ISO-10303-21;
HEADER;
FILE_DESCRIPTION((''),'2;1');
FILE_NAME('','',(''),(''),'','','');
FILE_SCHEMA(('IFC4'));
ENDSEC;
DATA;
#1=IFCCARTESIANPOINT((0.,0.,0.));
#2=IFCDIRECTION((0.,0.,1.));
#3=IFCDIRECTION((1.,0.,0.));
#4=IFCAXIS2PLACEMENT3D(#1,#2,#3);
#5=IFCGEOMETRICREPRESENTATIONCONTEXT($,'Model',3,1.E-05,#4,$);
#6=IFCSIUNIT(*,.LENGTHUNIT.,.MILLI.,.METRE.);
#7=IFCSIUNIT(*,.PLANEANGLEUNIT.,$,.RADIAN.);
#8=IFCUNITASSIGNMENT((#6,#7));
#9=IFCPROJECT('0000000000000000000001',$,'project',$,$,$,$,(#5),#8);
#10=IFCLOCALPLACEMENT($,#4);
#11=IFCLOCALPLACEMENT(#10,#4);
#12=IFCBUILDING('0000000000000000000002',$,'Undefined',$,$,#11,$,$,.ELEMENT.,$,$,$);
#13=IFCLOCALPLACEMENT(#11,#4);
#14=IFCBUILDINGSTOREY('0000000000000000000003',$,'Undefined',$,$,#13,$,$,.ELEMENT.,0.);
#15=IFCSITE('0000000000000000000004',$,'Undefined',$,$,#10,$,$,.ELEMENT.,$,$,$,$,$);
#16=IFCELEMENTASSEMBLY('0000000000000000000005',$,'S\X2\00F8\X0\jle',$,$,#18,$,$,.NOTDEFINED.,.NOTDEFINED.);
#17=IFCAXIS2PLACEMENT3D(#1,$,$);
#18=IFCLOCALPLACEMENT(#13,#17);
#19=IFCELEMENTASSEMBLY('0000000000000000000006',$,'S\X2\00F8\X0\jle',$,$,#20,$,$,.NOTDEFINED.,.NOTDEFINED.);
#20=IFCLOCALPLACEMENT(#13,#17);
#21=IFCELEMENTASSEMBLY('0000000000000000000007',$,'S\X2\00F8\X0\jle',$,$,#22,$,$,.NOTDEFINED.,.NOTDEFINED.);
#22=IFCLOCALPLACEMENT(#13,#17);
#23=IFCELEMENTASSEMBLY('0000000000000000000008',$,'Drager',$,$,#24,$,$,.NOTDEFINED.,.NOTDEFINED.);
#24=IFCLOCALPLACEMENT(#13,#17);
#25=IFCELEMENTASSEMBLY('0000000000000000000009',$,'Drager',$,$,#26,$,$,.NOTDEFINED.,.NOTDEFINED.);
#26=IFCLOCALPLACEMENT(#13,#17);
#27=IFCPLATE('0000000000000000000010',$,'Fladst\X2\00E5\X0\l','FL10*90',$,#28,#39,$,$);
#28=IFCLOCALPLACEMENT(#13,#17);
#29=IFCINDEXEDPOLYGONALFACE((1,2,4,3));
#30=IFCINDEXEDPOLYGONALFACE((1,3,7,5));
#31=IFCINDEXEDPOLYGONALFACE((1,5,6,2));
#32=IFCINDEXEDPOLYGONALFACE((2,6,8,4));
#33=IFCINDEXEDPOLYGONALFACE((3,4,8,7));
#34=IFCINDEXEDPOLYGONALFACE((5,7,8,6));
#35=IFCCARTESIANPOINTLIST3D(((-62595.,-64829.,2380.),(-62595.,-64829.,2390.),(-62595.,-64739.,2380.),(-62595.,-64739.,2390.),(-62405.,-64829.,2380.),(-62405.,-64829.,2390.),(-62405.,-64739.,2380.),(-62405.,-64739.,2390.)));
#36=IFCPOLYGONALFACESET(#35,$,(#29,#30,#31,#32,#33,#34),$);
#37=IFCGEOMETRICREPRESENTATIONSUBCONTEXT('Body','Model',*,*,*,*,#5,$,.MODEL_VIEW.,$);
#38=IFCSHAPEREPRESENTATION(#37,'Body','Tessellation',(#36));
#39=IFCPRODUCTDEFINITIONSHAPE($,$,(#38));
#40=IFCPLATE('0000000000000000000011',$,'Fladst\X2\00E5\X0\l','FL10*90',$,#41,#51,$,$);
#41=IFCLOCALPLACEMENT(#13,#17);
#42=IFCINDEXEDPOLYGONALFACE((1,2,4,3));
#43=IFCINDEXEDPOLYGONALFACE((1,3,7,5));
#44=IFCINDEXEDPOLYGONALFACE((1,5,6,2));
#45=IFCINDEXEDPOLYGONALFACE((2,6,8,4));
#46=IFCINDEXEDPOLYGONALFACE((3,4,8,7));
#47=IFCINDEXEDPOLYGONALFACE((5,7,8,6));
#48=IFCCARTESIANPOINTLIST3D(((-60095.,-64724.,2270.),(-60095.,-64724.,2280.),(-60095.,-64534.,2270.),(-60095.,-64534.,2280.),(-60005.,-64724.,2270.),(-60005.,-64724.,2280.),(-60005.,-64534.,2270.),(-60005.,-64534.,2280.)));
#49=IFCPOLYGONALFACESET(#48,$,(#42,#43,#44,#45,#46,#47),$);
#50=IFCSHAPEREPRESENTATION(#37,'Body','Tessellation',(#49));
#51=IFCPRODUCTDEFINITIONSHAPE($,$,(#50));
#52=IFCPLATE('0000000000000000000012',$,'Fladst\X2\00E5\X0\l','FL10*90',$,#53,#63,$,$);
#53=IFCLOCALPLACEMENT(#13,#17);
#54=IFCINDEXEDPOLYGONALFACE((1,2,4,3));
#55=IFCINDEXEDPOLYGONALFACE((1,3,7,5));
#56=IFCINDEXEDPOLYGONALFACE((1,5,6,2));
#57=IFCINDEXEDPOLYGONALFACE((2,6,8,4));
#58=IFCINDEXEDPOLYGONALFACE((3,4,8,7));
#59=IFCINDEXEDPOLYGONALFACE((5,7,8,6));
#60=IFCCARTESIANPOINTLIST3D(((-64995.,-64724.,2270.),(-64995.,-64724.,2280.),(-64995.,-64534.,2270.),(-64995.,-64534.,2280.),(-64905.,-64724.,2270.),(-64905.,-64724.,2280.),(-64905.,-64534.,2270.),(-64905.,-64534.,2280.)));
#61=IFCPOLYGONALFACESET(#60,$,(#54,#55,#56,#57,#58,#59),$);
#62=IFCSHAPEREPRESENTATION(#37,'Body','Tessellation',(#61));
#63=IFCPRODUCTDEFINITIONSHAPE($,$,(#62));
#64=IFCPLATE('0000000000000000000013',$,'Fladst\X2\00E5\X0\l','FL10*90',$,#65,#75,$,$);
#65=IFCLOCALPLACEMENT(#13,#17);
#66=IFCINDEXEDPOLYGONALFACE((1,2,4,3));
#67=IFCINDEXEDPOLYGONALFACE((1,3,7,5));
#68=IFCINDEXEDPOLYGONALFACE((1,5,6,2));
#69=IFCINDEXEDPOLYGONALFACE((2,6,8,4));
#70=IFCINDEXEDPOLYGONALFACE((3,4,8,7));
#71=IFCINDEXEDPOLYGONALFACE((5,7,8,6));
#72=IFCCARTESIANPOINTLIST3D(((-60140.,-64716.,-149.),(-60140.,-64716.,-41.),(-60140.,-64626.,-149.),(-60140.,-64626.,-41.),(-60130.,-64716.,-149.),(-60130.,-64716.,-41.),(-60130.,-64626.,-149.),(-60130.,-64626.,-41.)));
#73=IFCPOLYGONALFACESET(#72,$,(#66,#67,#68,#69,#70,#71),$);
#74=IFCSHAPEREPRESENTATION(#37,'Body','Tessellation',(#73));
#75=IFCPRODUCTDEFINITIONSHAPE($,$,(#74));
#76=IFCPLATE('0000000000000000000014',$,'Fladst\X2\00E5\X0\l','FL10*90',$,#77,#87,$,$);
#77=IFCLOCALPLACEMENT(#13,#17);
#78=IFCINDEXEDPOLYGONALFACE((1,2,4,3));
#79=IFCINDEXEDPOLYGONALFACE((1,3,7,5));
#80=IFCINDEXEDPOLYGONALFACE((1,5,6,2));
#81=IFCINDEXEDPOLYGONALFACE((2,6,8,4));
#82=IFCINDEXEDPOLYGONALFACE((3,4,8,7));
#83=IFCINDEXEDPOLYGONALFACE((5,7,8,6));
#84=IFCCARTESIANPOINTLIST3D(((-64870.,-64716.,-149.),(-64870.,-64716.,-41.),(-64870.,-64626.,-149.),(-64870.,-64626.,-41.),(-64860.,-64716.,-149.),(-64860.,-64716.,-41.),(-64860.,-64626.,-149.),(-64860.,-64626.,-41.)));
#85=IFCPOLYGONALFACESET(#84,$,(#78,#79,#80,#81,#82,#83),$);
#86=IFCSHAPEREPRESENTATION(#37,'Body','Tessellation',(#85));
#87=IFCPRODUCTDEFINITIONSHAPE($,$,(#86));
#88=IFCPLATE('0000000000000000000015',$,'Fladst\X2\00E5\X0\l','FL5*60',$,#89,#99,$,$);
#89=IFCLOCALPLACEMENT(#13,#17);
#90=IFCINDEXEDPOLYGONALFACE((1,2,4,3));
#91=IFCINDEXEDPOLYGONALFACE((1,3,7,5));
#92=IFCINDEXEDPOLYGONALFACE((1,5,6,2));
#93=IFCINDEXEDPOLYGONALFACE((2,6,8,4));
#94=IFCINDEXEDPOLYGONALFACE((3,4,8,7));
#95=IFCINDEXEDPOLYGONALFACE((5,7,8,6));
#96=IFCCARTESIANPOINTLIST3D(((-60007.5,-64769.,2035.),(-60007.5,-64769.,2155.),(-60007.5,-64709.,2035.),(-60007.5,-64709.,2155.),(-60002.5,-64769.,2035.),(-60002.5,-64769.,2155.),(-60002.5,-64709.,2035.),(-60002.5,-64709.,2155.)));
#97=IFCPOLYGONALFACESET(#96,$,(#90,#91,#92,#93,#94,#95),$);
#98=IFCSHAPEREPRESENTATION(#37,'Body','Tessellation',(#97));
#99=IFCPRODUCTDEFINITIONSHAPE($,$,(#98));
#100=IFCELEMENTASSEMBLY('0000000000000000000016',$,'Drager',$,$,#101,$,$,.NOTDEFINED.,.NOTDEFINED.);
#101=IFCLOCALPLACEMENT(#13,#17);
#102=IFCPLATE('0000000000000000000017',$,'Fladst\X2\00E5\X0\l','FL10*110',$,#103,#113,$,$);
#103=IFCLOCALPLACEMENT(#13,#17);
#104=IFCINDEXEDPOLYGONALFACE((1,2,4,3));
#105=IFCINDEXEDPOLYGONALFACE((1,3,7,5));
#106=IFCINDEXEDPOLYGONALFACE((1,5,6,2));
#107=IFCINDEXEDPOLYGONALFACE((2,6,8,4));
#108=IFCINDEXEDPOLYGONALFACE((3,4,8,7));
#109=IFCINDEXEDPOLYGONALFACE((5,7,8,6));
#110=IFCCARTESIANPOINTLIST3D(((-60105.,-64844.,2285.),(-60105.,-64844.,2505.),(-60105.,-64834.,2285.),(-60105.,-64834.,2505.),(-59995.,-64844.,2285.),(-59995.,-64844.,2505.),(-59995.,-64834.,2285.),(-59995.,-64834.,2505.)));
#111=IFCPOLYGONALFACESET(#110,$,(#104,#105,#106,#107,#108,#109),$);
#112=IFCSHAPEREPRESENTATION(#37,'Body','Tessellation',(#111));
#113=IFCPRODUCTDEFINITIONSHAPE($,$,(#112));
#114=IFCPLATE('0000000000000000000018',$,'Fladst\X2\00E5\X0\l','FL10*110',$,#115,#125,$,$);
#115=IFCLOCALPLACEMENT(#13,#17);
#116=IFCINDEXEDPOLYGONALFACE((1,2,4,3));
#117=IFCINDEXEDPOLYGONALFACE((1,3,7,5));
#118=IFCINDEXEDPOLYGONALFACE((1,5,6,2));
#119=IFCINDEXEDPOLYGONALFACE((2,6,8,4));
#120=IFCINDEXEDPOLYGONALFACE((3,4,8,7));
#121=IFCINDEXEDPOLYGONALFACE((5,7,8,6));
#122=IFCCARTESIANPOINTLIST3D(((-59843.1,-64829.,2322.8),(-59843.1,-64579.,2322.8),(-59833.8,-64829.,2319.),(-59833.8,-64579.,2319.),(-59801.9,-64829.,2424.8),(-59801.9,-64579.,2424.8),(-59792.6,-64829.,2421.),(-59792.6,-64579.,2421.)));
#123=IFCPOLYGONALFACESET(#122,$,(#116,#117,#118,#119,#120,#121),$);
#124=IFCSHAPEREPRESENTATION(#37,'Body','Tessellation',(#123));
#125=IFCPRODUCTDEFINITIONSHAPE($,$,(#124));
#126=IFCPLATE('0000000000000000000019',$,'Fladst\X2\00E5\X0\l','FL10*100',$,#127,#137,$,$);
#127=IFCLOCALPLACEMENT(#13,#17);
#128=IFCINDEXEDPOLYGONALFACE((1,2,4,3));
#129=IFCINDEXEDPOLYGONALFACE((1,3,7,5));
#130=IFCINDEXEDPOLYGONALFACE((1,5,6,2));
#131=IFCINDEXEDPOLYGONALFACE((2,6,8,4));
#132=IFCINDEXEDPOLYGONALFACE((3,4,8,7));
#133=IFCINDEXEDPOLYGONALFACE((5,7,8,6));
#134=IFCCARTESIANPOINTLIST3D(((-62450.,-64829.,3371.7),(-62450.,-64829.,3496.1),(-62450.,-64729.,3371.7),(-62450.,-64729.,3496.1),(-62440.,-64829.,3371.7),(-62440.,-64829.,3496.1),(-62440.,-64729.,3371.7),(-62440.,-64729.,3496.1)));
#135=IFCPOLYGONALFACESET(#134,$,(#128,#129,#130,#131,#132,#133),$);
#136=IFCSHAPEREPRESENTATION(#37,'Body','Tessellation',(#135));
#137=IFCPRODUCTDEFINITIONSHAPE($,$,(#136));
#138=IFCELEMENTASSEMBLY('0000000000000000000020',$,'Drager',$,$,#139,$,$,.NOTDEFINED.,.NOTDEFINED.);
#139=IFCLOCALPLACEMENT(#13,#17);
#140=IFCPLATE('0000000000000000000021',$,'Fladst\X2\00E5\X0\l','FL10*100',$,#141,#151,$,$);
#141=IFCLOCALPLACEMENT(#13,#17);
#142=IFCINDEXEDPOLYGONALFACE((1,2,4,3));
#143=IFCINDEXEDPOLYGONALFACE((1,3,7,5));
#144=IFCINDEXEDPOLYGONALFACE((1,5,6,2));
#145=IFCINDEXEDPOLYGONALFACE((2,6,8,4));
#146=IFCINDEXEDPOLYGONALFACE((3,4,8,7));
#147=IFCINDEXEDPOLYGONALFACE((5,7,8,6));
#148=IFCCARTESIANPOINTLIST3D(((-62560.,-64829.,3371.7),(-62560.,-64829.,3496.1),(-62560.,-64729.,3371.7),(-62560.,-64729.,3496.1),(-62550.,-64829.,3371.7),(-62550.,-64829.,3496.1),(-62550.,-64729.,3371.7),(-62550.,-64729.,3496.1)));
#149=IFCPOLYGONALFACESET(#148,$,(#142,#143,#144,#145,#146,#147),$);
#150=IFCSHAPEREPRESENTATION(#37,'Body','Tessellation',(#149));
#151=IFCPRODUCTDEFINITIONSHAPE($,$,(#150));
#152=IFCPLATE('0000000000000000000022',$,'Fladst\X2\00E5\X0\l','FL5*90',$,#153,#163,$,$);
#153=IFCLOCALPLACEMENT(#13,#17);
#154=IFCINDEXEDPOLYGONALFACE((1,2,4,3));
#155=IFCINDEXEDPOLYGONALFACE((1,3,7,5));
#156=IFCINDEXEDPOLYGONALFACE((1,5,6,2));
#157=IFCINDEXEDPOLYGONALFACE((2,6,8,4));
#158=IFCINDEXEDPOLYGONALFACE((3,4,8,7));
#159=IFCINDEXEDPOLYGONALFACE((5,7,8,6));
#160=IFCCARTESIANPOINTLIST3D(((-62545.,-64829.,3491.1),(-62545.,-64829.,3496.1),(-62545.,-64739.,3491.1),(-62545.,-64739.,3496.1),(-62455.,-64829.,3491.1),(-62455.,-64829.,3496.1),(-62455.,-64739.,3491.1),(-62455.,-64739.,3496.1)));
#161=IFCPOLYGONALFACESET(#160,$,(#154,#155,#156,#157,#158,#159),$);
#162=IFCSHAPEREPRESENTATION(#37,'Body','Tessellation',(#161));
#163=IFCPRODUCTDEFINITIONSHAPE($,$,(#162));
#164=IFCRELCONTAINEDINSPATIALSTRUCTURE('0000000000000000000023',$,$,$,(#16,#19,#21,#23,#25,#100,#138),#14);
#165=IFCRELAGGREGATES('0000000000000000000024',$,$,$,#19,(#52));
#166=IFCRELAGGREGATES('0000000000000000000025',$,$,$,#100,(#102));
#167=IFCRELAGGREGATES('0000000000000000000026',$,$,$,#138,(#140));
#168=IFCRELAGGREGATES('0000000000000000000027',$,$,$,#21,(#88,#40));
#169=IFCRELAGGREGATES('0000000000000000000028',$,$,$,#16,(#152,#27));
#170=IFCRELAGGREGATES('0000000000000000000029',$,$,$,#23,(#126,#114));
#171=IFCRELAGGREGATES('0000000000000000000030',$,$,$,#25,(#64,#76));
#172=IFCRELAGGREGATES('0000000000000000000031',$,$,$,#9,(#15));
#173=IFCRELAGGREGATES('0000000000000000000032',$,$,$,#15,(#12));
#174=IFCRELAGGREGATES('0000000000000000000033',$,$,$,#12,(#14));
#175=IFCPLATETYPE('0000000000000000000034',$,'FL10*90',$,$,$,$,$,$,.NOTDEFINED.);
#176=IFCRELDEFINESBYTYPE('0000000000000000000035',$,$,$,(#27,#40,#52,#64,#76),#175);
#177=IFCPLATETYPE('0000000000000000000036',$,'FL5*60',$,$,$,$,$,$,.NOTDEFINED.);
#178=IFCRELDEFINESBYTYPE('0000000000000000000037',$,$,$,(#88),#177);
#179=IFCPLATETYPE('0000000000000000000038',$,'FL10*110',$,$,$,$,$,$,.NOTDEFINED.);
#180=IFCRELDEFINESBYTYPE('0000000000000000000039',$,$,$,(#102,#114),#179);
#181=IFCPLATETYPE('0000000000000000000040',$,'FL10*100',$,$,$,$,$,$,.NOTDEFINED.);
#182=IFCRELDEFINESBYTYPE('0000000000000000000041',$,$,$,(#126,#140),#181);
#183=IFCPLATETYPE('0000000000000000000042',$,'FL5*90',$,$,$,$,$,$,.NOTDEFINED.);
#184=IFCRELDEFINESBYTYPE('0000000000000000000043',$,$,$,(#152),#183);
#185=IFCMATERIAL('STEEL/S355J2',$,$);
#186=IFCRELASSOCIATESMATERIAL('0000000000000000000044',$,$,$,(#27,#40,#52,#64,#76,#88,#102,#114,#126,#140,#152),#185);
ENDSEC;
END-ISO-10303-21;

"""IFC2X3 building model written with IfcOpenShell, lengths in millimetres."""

from ifc_helpers import new_model, si_unit, frame, origin_with_axes, place, context, subcontext, project, spatial, polyline, outline, extrude, material, type_object, element, aggregate, save


model = new_model("IFC2X3")

# Units and contexts
model_context = context("Model", 3, precision=1e-05, world=origin_with_axes())
body_context = subcontext(model_context, "Body", "Model", "MODEL_VIEW")
ifc_project = project(units=[si_unit("LENGTHUNIT", "METRE", prefix="MILLI"), si_unit("PLANEANGLEUNIT", "RADIAN")], contexts=[model_context])

# Site, building, storey
site_placement = place(None, origin_with_axes())
site = spatial("IfcSite", under=ifc_project, at=site_placement, Name="Undefined", CompositionType="ELEMENT")
building_placement = place(site_placement, origin_with_axes())
building = spatial("IfcBuilding", under=site, at=building_placement, Name="Undefined", CompositionType="ELEMENT")
storey_placement = place(building_placement, origin_with_axes())
storey = spatial("IfcBuildingStorey", under=building, at=storey_placement, Name="Undefined", CompositionType="ELEMENT", Elevation=0.0)

# Element assembly
assembly_1_placement = place(storey_placement, origin_with_axes())
assembly_1 = element("IfcElementAssembly", 1, at=assembly_1_placement, inside=storey, Name="Søjle", AssemblyPlace="NOTDEFINED", PredefinedType="NOTDEFINED")

# Element assemblies
assembly_2_placement = place(storey_placement, origin_with_axes())
assembly_2 = element("IfcElementAssembly", 2, at=assembly_2_placement, inside=storey, Name="Søjle", AssemblyPlace="NOTDEFINED", PredefinedType="NOTDEFINED")
ifc_material_1 = material(Name="STEEL/S355J2")
assembly_3_placement = place(storey_placement, origin_with_axes())
assembly_3 = element("IfcElementAssembly", 3, at=assembly_3_placement, inside=storey, Name="Søjle", AssemblyPlace="NOTDEFINED", PredefinedType="NOTDEFINED")

# Element assembly
assembly_4_placement = place(storey_placement, origin_with_axes())
assembly_4 = element("IfcElementAssembly", 4, at=assembly_4_placement, inside=storey, Name="Drager", AssemblyPlace="NOTDEFINED", PredefinedType="NOTDEFINED")

# Element assembly
assembly_5_placement = place(storey_placement, origin_with_axes())
assembly_5 = element("IfcElementAssembly", 5, at=assembly_5_placement, inside=storey, Name="Drager", AssemblyPlace="NOTDEFINED", PredefinedType="NOTDEFINED")

# Shared definitions
plate_type_1 = type_object("IfcPlateType", Name="FL10*90", PredefinedType="NOTDEFINED")

# Plates
plate_1_placement = place(assembly_1_placement, frame((-62405.0, -64784.0, 2385.0), z_axis=(0.0, 0.0, 1.0), x_axis=(-1.0, 0.0, 0.0)))
plate_1 = element("IfcPlate", 6, at=plate_1_placement, type_object=plate_type_1, material=ifc_material_1, Name="Fladstål", Description="FL10*90", context=body_context, shape_type="SweptSolid", body=[
    extrude(outline(polyline([(0.0, -45.0), (0.0, 45.0), (190.0, 45.0), (190.0, -45.0), (0.0, -45.0)])), frame((0.0, 0.0, -5.0), z_axis=(0.0, 0.0, 1.0), x_axis=(1.0, 0.0, 0.0)), (0.0, 0.0, 1.0), 10.0),
])
plate_2_placement = place(assembly_3_placement, frame((-60050.0, -64724.0, 2275.0), z_axis=(0.0, 0.0, -1.0), x_axis=(0.0, 1.0, 0.0)))
plate_2 = element("IfcPlate", 7, at=plate_2_placement, type_object=plate_type_1, material=ifc_material_1, Name="Fladstål", Description="FL10*90", context=body_context, shape_type="SweptSolid", body=[
    extrude(outline(polyline([(0.0, -45.0), (0.0, 45.0), (190.0, 45.0), (190.0, -45.0), (0.0, -45.0)])), frame((0.0, 0.0, -5.0), z_axis=(0.0, 0.0, 1.0), x_axis=(1.0, 0.0, 0.0)), (0.0, 0.0, 1.0), 10.0),
])
plate_3_placement = place(assembly_2_placement, frame((-64950.0, -64724.0, 2275.0), z_axis=(0.0, 0.0, -1.0), x_axis=(0.0, 1.0, 0.0)))
plate_3 = element("IfcPlate", 8, at=plate_3_placement, type_object=plate_type_1, material=ifc_material_1, Name="Fladstål", Description="FL10*90", context=body_context, shape_type="SweptSolid", body=[
    extrude(outline(polyline([(0.0, -45.0), (0.0, 45.0), (190.0, 45.0), (190.0, -45.0), (0.0, -45.0)])), frame((0.0, 0.0, -5.0), z_axis=(0.0, 0.0, 1.0), x_axis=(1.0, 0.0, 0.0)), (0.0, 0.0, 1.0), 10.0),
])
aggregate(assembly_2, [plate_3])
plate_4_placement = place(assembly_5_placement, frame((-60135.0, -64671.0, -41.0), z_axis=(-1.0, 0.0, 0.0), x_axis=(0.0, 0.0, -1.0)))
plate_4 = element("IfcPlate", 9, at=plate_4_placement, type_object=plate_type_1, material=ifc_material_1, Name="Fladstål", Description="FL10*90", context=body_context, shape_type="SweptSolid", body=[
    extrude(outline(polyline([(0.0, -45.0), (0.0, 45.0), (108.0, 45.0), (108.0, -45.0), (0.0, -45.0)])), frame((0.0, 0.0, -5.0), z_axis=(0.0, 0.0, 1.0), x_axis=(1.0, 0.0, 0.0)), (0.0, 0.0, 1.0), 10.0),
])
plate_5_placement = place(assembly_5_placement, frame((-64865.0, -64671.0, -149.0), z_axis=(1.0, 0.0, 0.0), x_axis=(0.0, 0.0, 1.0)))
plate_5 = element("IfcPlate", 10, at=plate_5_placement, type_object=plate_type_1, material=ifc_material_1, Name="Fladstål", Description="FL10*90", context=body_context, shape_type="SweptSolid", body=[
    extrude(outline(polyline([(0.0, -45.0), (0.0, 45.0), (108.0, 45.0), (108.0, -45.0), (0.0, -45.0)])), frame((0.0, 0.0, -5.0), z_axis=(0.0, 0.0, 1.0), x_axis=(1.0, 0.0, 0.0)), (0.0, 0.0, 1.0), 10.0),
])
plate_type_2 = type_object("IfcPlateType", Name="FL5*60", PredefinedType="NOTDEFINED")
plate_6_placement = place(assembly_3_placement, frame((-60005.0, -64769.0, 2095.0), z_axis=(1.0, 0.0, 0.0), x_axis=(0.0, 1.0, 0.0)))
plate_6 = element("IfcPlate", 11, at=plate_6_placement, type_object=plate_type_2, material=ifc_material_1, Name="Fladstål", Description="FL5*60", context=body_context, shape_type="SweptSolid", body=[
    extrude(outline(polyline([(0.0, -60.0), (0.0, 60.0), (60.0, 60.0), (60.0, -60.0), (0.0, -60.0)])), frame((0.0, 0.0, -2.5), z_axis=(0.0, 0.0, 1.0), x_axis=(1.0, 0.0, 0.0)), (0.0, 0.0, 1.0), 5.0),
])

# Element assembly, plate
assembly_6_placement = place(storey_placement, origin_with_axes())
assembly_6 = element("IfcElementAssembly", 12, at=assembly_6_placement, inside=storey, Name="Drager", AssemblyPlace="NOTDEFINED", PredefinedType="NOTDEFINED")
plate_type_3 = type_object("IfcPlateType", Name="FL10*110", PredefinedType="NOTDEFINED")
plate_7_placement = place(assembly_6_placement, frame((-60050.0, -64839.0, 2285.0), z_axis=(0.0, -1.0, 0.0), x_axis=(0.0, 0.0, 1.0)))
plate_7 = element("IfcPlate", 13, at=plate_7_placement, type_object=plate_type_3, material=ifc_material_1, Name="Fladstål", Description="FL10*110", context=body_context, shape_type="SweptSolid", body=[
    extrude(outline(polyline([(0.0, -55.0), (0.0, 55.0), (220.0, 55.0), (220.0, -55.0), (0.0, -55.0)])), frame((0.0, 0.0, -5.0), z_axis=(0.0, 0.0, 1.0), x_axis=(1.0, 0.0, 0.0)), (0.0, 0.0, 1.0), 10.0),
])
aggregate(assembly_6, [plate_7])

# Plates
plate_8_placement = place(assembly_4_placement, frame((-59817.8, -64829.0, 2371.9), z_axis=(-0.927179, 0.0, 0.374619), x_axis=(0.0, 1.0, 0.0)))
plate_8 = element("IfcPlate", 14, at=plate_8_placement, type_object=plate_type_3, material=ifc_material_1, Name="Fladstål", Description="FL10*110", context=body_context, shape_type="SweptSolid", body=[
    extrude(outline(polyline([(0.0, -55.0), (0.0, 55.0), (250.0, 55.0), (250.0, -55.0), (0.0, -55.0)])), frame((0.0, 0.0, -5.0), z_axis=(0.0, 0.0, 1.0), x_axis=(1.0, 0.0, 0.0)), (0.0, 0.0, 1.0), 10.0),
])
plate_type_4 = type_object("IfcPlateType", Name="FL10*100", PredefinedType="NOTDEFINED")
plate_9_placement = place(assembly_4_placement, frame((-62445.0, -64779.0, 3371.7), z_axis=(-1.0, 0.0, 0.0), x_axis=(0.0, 0.0, 1.0)))
plate_9 = element("IfcPlate", 15, at=plate_9_placement, type_object=plate_type_4, material=ifc_material_1, Name="Fladstål", Description="FL10*100", context=body_context, shape_type="SweptSolid", body=[
    extrude(outline(polyline([(0.0, -50.0), (0.0, 50.0), (124.4, 50.0), (124.4, -50.0), (0.0, -50.0)])), frame((0.0, 0.0, -5.0), z_axis=(0.0, 0.0, 1.0), x_axis=(1.0, 0.0, 0.0)), (0.0, 0.0, 1.0), 10.0),
])

# Element assembly, plate
assembly_7_placement = place(storey_placement, origin_with_axes())
assembly_7 = element("IfcElementAssembly", 16, at=assembly_7_placement, inside=storey, Name="Drager", AssemblyPlace="NOTDEFINED", PredefinedType="NOTDEFINED")
plate_10_placement = place(assembly_7_placement, frame((-62555.0, -64779.0, 3371.7), z_axis=(-1.0, 0.0, 0.0), x_axis=(0.0, 0.0, 1.0)))
plate_10 = element("IfcPlate", 17, at=plate_10_placement, type_object=plate_type_4, material=ifc_material_1, Name="Fladstål", Description="FL10*100", context=body_context, shape_type="SweptSolid", body=[
    extrude(outline(polyline([(0.0, -50.0), (0.0, 50.0), (124.4, 50.0), (124.4, -50.0), (0.0, -50.0)])), frame((0.0, 0.0, -5.0), z_axis=(0.0, 0.0, 1.0), x_axis=(1.0, 0.0, 0.0)), (0.0, 0.0, 1.0), 10.0),
])
aggregate(assembly_7, [plate_10])

# Plate
plate_type_5 = type_object("IfcPlateType", Name="FL5*90", PredefinedType="NOTDEFINED")
plate_11_placement = place(assembly_1_placement, frame((-62500.0, -64829.0, 3493.6), z_axis=(0.0, 0.0, -1.0), x_axis=(0.0, 1.0, 0.0)))
plate_11 = element("IfcPlate", 18, at=plate_11_placement, type_object=plate_type_5, material=ifc_material_1, Name="Fladstål", Description="FL5*90", context=body_context, shape_type="SweptSolid", body=[
    extrude(outline(polyline([(0.0, -45.0), (0.0, 45.0), (90.0, 45.0), (90.0, -45.0), (0.0, -45.0)])), frame((0.0, 0.0, -2.5), z_axis=(0.0, 0.0, 1.0), x_axis=(1.0, 0.0, 0.0)), (0.0, 0.0, 1.0), 5.0),
])

aggregate(assembly_3, [plate_6, plate_2])
aggregate(assembly_1, [plate_11, plate_1])
aggregate(assembly_4, [plate_9, plate_8])
aggregate(assembly_5, [plate_4, plate_5])

save(model, "model.ifc")
